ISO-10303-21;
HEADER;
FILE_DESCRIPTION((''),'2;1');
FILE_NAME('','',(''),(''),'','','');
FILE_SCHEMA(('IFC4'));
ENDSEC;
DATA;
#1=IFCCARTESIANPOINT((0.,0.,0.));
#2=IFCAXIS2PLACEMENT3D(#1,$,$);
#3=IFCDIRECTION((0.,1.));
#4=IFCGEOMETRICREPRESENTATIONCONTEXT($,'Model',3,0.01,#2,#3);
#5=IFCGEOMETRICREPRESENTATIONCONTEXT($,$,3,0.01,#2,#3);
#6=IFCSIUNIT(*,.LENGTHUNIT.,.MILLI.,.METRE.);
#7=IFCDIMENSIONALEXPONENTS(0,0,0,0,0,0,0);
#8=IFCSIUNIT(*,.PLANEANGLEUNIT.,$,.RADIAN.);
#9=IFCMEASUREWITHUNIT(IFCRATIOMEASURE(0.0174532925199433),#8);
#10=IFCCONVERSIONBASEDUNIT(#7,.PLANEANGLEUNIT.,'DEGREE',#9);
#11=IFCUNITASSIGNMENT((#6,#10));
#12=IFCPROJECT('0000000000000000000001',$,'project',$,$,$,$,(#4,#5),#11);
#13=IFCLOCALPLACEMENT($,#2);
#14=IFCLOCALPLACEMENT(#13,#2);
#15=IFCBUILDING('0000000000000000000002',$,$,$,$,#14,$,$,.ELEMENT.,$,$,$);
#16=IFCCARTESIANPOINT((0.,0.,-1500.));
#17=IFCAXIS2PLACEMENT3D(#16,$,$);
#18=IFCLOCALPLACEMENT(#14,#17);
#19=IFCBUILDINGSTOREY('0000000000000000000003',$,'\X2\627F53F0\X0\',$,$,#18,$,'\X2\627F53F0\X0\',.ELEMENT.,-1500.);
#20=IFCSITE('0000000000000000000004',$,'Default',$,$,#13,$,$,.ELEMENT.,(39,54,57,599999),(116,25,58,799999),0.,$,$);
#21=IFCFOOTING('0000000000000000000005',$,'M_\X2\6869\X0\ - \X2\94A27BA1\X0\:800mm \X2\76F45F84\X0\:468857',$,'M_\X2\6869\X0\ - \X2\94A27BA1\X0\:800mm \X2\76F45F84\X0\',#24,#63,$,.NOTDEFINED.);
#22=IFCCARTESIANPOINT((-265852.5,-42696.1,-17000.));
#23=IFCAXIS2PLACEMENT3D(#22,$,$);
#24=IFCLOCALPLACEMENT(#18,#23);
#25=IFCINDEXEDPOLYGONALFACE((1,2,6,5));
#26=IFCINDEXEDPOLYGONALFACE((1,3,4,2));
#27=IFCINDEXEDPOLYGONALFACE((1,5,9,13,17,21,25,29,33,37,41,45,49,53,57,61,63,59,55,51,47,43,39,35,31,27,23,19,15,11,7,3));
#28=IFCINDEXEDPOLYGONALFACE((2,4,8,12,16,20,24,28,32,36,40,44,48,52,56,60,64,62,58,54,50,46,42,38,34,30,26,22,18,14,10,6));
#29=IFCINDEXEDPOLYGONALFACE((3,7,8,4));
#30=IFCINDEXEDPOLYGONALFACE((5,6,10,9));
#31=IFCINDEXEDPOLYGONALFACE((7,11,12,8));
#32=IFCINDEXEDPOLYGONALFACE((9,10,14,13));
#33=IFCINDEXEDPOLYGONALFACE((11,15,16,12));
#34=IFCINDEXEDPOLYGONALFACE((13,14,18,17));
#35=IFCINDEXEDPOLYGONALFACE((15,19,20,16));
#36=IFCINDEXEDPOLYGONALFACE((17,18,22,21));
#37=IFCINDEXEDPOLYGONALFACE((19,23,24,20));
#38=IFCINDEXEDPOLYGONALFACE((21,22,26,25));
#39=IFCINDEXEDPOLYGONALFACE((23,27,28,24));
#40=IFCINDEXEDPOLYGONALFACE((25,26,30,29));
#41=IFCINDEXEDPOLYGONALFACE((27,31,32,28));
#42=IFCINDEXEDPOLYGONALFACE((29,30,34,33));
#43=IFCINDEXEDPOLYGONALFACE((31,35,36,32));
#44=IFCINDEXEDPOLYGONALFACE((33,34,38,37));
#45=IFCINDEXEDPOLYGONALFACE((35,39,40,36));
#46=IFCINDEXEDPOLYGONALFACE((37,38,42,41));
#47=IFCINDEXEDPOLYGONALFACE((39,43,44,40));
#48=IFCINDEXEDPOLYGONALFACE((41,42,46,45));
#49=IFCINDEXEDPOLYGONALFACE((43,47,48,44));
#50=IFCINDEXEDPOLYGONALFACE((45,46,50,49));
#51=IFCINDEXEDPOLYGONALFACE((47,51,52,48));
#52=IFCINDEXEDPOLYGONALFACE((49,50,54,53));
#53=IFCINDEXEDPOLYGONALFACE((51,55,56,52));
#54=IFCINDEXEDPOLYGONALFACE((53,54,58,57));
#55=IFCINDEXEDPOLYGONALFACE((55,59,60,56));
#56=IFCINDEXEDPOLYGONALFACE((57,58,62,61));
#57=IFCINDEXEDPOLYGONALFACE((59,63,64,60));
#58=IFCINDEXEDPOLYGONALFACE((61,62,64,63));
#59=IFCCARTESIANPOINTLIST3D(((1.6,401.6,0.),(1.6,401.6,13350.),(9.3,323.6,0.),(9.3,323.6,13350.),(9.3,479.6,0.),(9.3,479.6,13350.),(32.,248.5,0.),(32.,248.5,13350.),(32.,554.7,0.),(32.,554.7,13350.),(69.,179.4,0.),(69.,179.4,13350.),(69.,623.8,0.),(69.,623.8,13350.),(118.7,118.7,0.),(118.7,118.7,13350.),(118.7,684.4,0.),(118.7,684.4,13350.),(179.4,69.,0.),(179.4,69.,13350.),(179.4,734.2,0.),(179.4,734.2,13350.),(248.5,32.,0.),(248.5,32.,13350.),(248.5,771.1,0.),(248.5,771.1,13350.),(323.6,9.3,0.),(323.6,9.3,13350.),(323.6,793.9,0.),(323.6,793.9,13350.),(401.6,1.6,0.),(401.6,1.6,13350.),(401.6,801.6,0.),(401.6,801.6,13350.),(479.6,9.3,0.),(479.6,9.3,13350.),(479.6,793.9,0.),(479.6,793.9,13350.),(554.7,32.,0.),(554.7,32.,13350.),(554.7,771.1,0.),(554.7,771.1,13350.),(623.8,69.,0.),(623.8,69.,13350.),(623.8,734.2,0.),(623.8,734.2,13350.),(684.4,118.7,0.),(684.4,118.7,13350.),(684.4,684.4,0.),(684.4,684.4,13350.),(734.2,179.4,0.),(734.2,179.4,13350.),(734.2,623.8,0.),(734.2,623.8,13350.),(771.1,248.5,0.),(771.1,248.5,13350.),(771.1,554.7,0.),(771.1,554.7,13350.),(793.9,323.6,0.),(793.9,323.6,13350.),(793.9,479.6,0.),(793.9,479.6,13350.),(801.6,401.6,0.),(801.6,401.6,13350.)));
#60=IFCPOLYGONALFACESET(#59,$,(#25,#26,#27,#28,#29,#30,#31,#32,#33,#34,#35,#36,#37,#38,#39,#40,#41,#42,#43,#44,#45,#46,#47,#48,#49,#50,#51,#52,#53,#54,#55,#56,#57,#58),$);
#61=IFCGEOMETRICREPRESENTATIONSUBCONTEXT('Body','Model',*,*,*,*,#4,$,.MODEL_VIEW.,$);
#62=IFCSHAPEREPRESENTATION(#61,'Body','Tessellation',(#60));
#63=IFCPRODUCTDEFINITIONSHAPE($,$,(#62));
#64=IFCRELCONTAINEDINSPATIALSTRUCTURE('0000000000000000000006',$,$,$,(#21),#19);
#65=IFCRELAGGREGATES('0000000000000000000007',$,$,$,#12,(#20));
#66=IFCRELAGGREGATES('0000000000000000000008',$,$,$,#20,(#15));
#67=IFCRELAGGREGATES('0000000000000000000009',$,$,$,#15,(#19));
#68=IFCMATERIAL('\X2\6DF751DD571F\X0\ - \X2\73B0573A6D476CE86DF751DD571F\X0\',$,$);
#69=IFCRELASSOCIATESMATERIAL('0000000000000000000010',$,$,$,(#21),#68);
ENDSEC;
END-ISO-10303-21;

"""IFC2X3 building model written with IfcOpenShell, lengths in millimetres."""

from ifc_helpers import new_model, entity, si_unit, converted_unit, direction, frame, origin, origin_2d_with_axis, place, context, subcontext, project, spatial, circle, extrude, material, element, save


model = new_model("IFC2X3")

# Units and contexts
model_context = context("Model", 3, precision=0.01, world=origin(), true_north=direction((0.0, 1.0)))
context_of_model = context(None, 3, precision=0.01, world=origin(), true_north=direction((0.0, 1.0)))
body_context = subcontext(model_context, "Body", "Model", "MODEL_VIEW")
ifc_project = project(units=[si_unit("LENGTHUNIT", "METRE", prefix="MILLI"), converted_unit("PLANEANGLEUNIT", "DEGREE", entity("IfcRatioMeasure", 0.0174532925199433), si_unit("PLANEANGLEUNIT", "RADIAN"), dimensions=[0, 0, 0, 0, 0, 0, 0])], contexts=[model_context, context_of_model])

# Site, building, storey
site_placement = place(None, origin())
site = spatial("IfcSite", under=ifc_project, at=site_placement, Name="Default", CompositionType="ELEMENT", RefLatitude=(39, 54, 57, 599999), RefLongitude=(116, 25, 58, 799999), RefElevation=0.0)
building_placement = place(site_placement, origin())
building = spatial("IfcBuilding", under=site, at=building_placement, CompositionType="ELEMENT")
storey_placement = place(building_placement, frame((0.0, 0.0, -1500.0)))
storey = spatial("IfcBuildingStorey", under=building, at=storey_placement, Name="承台", LongName="承台", CompositionType="ELEMENT", Elevation=-1500.0)

# Footing
ifc_material_1 = material(Name="混凝土 - 现场浇注混凝土")
footing_1_placement = place(storey_placement, frame((-265852.5, -42696.1, -17000.0)))
element("IfcFooting", 1, at=footing_1_placement, inside=storey, material=ifc_material_1, Name="M_桩 - 钢管:800mm 直径:468857", ObjectType="M_桩 - 钢管:800mm 直径", PredefinedType="NOTDEFINED", context=body_context, shape_type="SweptSolid", body=[
    extrude(circle(Radius=400.0, at=origin_2d_with_axis()), frame((401.6, 401.6, 0.0), z_axis=(0.0, 0.0, 1.0), x_axis=(0.0, 1.0, 0.0)), (0.0, 0.0, 1.0), 13350.0),
])

save(model, "model.ifc")
